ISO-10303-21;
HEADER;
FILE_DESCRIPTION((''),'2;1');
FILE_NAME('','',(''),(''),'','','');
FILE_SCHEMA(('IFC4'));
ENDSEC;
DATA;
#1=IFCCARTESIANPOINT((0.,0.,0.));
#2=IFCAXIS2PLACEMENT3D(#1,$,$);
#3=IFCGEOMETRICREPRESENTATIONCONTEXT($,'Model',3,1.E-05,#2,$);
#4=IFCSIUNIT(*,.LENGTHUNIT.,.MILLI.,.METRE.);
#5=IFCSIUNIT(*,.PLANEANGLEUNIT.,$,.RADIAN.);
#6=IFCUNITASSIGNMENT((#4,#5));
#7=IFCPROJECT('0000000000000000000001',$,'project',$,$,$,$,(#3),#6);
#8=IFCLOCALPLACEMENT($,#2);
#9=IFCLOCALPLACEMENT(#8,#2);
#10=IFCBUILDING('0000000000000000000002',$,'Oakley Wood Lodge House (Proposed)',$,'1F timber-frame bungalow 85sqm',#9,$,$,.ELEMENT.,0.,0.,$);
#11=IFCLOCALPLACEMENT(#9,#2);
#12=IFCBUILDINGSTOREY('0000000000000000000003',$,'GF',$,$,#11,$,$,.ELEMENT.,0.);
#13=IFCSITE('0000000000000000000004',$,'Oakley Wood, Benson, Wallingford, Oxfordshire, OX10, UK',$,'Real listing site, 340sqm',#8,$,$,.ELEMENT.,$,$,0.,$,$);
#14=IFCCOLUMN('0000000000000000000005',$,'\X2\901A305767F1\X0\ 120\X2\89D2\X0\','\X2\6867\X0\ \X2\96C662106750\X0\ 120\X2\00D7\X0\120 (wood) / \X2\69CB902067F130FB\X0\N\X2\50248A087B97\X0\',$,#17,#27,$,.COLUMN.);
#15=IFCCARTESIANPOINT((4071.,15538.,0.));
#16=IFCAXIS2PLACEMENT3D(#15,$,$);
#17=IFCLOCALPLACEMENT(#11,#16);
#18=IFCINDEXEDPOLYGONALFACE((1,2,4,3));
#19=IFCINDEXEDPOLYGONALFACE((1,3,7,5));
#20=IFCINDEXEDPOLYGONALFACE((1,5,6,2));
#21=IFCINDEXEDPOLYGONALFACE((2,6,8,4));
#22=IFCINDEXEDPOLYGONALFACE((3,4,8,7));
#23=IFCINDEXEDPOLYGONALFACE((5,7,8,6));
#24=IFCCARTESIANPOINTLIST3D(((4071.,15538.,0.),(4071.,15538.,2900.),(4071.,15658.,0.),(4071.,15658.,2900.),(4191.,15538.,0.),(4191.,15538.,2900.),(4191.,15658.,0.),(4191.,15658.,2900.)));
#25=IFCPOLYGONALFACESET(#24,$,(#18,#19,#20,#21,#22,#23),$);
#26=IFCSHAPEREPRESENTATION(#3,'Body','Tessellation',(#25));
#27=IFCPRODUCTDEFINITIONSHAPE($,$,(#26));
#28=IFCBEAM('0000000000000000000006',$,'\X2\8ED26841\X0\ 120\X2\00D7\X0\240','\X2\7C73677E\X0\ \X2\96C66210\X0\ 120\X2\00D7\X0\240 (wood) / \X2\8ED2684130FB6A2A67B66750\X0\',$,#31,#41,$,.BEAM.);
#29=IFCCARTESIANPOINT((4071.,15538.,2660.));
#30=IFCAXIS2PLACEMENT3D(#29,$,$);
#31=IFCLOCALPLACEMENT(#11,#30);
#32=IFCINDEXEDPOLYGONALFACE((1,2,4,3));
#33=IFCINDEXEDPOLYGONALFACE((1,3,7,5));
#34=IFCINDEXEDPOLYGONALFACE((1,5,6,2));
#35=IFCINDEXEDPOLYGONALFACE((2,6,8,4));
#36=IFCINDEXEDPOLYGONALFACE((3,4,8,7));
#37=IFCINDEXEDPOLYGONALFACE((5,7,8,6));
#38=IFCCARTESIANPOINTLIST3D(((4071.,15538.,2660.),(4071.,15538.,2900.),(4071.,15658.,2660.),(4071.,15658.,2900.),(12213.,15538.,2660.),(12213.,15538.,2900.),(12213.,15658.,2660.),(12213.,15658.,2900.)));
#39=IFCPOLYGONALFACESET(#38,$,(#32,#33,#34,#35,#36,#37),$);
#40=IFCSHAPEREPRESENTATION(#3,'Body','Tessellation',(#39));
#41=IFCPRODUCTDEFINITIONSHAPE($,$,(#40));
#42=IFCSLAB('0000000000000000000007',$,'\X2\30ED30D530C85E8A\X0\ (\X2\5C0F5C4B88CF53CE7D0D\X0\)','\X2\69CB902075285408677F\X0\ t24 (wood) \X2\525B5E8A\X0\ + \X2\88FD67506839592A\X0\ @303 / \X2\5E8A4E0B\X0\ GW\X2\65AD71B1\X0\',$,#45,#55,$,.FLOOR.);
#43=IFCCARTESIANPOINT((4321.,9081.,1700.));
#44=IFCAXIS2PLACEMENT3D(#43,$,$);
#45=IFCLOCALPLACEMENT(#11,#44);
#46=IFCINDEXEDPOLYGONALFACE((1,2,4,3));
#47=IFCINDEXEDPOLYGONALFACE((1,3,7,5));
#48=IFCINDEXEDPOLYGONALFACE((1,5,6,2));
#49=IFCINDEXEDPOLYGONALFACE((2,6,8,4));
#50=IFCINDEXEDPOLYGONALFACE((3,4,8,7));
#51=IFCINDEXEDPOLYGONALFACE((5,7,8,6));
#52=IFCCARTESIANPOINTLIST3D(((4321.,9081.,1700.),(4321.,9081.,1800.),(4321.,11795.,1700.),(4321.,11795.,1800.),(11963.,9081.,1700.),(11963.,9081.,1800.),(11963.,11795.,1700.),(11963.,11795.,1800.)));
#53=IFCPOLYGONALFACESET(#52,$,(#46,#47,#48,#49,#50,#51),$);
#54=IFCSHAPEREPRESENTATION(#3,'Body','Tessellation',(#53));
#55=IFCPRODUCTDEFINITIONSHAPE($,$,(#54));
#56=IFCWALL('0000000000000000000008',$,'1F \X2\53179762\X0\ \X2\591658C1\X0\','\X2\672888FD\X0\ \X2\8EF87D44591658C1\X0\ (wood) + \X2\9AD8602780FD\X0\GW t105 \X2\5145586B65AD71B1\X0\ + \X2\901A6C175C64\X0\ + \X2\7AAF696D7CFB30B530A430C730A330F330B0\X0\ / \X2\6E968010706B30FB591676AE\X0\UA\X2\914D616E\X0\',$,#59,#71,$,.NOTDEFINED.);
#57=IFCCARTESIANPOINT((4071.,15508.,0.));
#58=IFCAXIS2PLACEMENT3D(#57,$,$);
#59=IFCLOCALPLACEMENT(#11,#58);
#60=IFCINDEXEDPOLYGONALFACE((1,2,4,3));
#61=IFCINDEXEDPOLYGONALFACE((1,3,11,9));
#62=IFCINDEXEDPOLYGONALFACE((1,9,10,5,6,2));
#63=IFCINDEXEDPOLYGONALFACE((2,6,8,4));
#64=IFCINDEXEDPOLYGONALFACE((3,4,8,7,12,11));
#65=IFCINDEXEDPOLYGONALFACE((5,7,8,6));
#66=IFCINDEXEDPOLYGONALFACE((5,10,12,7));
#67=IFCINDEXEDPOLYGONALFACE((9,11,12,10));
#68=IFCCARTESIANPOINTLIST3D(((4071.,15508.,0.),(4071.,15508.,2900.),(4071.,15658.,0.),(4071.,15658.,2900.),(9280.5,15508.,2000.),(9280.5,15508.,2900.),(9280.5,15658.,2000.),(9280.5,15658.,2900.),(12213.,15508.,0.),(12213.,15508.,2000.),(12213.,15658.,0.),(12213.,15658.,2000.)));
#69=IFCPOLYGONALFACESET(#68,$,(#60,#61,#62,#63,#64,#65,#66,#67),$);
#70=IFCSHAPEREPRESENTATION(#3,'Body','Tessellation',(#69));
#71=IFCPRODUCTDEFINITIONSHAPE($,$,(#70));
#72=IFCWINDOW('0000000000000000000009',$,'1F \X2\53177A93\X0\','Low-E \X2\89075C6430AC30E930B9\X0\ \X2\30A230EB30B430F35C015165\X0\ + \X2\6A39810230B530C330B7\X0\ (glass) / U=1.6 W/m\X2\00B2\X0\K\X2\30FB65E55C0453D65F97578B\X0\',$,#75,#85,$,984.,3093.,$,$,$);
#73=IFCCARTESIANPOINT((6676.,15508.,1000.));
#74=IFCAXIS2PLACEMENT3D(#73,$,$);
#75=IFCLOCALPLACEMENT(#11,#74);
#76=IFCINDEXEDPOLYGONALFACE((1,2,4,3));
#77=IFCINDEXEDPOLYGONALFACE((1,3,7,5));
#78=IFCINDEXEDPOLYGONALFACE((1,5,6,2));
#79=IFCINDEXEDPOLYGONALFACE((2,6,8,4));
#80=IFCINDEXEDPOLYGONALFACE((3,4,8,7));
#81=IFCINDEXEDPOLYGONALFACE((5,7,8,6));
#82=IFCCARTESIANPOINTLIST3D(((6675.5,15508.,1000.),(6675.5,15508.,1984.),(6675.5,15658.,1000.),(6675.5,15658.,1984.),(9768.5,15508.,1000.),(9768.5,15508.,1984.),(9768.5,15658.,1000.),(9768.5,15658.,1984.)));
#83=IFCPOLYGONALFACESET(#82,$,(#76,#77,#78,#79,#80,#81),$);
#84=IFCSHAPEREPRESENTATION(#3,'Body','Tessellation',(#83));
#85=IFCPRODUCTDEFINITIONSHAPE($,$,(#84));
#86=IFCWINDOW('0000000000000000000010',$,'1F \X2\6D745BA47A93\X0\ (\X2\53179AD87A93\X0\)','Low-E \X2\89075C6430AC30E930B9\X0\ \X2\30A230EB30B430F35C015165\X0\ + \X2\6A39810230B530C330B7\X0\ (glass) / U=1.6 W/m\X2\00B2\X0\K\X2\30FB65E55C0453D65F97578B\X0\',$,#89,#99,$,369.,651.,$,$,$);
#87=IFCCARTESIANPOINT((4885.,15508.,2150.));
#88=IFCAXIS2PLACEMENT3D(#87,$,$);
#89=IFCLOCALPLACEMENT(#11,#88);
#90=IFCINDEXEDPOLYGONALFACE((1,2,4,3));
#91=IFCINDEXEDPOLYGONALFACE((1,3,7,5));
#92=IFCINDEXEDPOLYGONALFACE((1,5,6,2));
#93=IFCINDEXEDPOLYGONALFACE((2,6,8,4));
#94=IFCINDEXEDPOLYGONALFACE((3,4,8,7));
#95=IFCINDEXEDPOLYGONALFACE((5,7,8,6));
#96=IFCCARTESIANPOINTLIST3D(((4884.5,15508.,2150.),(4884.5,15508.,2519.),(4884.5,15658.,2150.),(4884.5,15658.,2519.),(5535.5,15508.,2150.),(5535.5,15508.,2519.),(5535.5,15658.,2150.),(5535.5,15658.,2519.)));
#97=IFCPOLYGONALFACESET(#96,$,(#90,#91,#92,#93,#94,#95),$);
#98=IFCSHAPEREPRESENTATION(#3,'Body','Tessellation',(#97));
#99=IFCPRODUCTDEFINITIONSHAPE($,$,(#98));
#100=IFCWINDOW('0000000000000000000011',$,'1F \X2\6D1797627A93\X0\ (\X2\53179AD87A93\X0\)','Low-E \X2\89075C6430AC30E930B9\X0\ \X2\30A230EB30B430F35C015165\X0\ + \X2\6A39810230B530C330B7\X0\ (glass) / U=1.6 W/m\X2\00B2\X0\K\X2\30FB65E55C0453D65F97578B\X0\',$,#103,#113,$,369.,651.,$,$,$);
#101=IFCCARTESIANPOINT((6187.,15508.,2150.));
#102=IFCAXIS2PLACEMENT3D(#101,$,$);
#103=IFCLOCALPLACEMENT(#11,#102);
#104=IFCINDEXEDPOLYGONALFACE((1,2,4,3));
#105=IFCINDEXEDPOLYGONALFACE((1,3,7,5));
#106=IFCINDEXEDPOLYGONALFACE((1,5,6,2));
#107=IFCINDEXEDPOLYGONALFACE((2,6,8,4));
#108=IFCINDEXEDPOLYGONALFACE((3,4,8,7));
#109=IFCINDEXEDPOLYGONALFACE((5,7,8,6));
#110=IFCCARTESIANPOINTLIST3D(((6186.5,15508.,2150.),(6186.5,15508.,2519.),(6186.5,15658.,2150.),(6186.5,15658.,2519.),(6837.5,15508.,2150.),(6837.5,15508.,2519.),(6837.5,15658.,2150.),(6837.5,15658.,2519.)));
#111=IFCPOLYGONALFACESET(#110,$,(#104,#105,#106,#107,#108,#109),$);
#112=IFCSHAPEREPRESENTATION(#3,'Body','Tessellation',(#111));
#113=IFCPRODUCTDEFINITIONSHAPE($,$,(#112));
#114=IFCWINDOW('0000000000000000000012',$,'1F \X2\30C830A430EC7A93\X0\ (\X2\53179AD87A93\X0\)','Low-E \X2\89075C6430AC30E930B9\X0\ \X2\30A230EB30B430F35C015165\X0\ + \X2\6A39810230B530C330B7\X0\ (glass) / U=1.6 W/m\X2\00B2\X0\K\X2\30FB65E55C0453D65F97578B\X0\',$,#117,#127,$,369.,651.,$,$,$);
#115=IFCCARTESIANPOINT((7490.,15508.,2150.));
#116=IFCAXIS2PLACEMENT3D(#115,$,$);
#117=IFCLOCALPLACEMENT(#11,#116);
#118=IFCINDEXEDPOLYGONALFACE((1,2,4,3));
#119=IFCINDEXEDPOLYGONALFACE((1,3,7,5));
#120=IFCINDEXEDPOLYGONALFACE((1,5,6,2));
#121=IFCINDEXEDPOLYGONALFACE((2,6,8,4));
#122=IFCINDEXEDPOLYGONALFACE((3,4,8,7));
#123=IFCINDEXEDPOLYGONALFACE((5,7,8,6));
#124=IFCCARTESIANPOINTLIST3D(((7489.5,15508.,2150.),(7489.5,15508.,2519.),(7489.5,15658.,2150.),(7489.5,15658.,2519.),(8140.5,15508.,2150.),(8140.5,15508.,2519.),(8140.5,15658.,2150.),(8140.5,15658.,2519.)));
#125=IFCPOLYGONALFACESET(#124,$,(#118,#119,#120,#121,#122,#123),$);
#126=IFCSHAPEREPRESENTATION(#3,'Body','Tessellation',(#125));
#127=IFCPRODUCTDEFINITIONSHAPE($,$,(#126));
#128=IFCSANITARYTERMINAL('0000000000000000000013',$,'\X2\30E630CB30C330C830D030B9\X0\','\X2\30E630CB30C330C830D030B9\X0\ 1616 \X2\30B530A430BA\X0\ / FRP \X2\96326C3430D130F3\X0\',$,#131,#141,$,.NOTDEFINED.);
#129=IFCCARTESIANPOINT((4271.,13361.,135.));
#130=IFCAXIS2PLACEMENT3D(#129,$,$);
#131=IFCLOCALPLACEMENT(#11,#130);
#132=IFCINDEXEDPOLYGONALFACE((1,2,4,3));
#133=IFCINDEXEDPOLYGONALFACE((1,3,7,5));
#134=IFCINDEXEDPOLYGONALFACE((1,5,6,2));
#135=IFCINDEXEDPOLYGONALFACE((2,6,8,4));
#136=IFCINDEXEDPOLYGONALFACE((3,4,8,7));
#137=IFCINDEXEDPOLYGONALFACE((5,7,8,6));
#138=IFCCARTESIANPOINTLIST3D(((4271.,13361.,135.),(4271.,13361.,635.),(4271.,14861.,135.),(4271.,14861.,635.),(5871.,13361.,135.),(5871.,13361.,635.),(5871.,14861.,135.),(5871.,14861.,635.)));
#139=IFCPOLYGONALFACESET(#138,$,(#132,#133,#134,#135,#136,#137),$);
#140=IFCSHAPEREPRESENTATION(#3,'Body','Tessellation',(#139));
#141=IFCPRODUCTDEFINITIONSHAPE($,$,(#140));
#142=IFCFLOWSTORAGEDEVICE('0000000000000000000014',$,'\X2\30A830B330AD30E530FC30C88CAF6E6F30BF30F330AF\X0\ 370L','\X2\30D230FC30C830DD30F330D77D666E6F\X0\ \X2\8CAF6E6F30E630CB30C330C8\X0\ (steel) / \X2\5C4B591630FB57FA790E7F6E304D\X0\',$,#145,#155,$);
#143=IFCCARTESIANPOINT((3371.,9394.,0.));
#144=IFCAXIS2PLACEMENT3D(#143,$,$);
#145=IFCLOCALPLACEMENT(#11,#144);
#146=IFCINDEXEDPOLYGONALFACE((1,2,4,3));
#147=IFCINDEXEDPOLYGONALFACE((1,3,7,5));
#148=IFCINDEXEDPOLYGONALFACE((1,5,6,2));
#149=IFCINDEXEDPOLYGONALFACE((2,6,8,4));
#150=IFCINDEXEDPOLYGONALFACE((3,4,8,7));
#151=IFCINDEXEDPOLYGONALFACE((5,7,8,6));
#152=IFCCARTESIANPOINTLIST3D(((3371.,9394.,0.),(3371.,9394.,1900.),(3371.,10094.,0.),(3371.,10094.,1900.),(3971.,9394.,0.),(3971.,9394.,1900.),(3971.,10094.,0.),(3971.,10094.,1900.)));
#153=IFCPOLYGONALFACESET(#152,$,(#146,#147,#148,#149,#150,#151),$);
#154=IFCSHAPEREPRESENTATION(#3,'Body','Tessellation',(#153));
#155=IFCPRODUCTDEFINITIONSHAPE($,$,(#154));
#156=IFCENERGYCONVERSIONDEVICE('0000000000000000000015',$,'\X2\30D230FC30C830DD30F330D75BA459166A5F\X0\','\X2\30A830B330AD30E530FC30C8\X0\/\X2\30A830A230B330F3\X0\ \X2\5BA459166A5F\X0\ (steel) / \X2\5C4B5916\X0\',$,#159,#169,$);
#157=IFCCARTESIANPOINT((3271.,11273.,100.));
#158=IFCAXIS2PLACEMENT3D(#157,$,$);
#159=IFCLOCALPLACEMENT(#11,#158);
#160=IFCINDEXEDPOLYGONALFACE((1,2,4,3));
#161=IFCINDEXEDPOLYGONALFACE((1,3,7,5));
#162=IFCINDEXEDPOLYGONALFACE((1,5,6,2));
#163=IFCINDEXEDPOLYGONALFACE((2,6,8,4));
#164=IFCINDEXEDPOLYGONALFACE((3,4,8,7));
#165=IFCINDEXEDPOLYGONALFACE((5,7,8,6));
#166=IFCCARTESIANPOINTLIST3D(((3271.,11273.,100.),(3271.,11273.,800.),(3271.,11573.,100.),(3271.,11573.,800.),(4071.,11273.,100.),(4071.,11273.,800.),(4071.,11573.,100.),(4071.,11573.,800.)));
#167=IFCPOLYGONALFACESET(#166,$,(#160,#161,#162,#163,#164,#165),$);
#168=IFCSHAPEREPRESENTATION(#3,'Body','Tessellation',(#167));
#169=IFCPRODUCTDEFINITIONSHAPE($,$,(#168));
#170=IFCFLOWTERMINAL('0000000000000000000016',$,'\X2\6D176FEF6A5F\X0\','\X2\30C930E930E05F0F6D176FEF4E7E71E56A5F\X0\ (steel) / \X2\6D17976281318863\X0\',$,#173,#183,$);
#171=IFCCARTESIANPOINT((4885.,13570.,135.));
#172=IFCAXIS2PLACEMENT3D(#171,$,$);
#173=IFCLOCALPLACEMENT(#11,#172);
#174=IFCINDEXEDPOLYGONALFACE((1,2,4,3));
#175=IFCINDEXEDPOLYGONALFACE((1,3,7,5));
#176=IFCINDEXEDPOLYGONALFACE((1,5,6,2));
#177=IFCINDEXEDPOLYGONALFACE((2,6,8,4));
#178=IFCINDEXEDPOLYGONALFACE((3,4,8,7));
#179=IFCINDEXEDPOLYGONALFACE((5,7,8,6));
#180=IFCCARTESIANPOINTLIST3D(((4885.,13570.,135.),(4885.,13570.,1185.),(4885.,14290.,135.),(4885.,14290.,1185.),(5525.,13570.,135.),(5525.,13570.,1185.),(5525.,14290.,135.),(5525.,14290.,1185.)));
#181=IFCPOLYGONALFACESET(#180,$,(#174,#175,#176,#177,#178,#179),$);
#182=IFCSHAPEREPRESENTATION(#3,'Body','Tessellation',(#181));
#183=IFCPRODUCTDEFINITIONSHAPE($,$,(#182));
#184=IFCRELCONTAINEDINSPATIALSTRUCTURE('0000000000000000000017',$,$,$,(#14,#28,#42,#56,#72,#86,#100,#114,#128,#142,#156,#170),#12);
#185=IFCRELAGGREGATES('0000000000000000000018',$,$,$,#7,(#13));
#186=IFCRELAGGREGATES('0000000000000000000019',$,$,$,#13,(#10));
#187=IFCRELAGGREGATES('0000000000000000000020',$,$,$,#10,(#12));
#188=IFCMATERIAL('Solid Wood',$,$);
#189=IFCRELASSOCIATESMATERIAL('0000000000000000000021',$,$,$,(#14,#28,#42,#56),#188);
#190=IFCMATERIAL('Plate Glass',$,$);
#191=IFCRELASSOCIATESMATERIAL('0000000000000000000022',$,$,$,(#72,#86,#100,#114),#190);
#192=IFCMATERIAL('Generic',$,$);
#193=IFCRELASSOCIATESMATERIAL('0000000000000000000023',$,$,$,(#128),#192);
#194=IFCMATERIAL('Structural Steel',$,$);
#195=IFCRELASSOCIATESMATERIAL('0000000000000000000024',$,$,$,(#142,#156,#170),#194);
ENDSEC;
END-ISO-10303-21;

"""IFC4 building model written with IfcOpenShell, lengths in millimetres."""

from ifc_helpers import new_model, si_unit, frame, frame_2d, origin, place, context, project, spatial, rectangle, extrude, material, element, fill, save


model = new_model("IFC4")

# Units and contexts
model_context = context("Model", 3, precision=1e-05, world=origin())
ifc_project = project(units=[si_unit("LENGTHUNIT", "METRE", prefix="MILLI"), si_unit("PLANEANGLEUNIT", "RADIAN")], contexts=[model_context])

# Site, building, storey
site_placement = place(None, origin())
site = spatial("IfcSite", under=ifc_project, at=site_placement, Name="Oakley Wood, Benson, Wallingford, Oxfordshire, OX10, UK", ObjectType="Real listing site, 340sqm", CompositionType="ELEMENT", RefElevation=0.0)
building_placement = place(site_placement, origin())
building = spatial("IfcBuilding", under=site, at=building_placement, Name="Oakley Wood Lodge House (Proposed)", ObjectType="1F timber-frame bungalow 85sqm", CompositionType="ELEMENT", ElevationOfRefHeight=0.0, ElevationOfTerrain=0.0)
storey_placement = place(building_placement, origin())
storey = spatial("IfcBuildingStorey", under=building, at=storey_placement, Name="GF", CompositionType="ELEMENT", Elevation=0.0)

# Column
ifc_material_1 = material(Name="Solid Wood")
column_1_placement = place(storey_placement, frame((4071.0, 15538.0, 0.0)))
element("IfcColumn", 1, at=column_1_placement, inside=storey, material=ifc_material_1, Name="通し柱 120角", Description="桧 集成材 120×120 (wood) / 構造柱・N値計算", PredefinedType="COLUMN", context=model_context, shape_type="SweptSolid", body=[
    extrude(rectangle(XDim=120.0, YDim=120.0, at=frame_2d((60.0, 60.0))), frame((4071.0, 15538.0, 0.0)), (0.0, 0.0, 1.0), 2900.0),
])

# Beam
beam_1_placement = place(storey_placement, frame((4071.0, 15538.0, 2660.0)))
element("IfcBeam", 2, at=beam_1_placement, inside=storey, material=ifc_material_1, Name="軒桁 120×240", Description="米松 集成 120×240 (wood) / 軒桁・横架材", PredefinedType="BEAM", context=model_context, shape_type="SweptSolid", body=[
    extrude(rectangle(XDim=8142.0, YDim=120.0, at=frame_2d((4071.0, 60.0))), frame((4071.0, 15538.0, 2660.0)), (0.0, 0.0, 1.0), 240.0),
])

# Slab
slab_placement = place(storey_placement, frame((4321.0, 9081.0, 1700.0)))
element("IfcSlab", 3, at=slab_placement, inside=storey, material=ifc_material_1, Name="ロフト床 (小屋裏収納)", Description="構造用合板 t24 (wood) 剛床 + 製材根太 @303 / 床下 GW断熱", PredefinedType="FLOOR", context=model_context, shape_type="SweptSolid", body=[
    extrude(rectangle(XDim=7642.0, YDim=2714.0, at=frame_2d((3821.0, 1357.0))), frame((4321.0, 9081.0, 1700.0)), (0.0, 0.0, 1.0), 100.0),
])

# Wall, openings, windows
wall_1_placement = place(storey_placement, frame((4071.0, 15508.0, 0.0)))
wall_1 = element("IfcWall", 4, at=wall_1_placement, inside=storey, material=ifc_material_1, Name="1F 北面 外壁", Description="木製 軸組外壁 (wood) + 高性能GW t105 充填断熱 + 通気層 + 窯業系サイディング / 準耐火・外皮UA配慮", PredefinedType="NOTDEFINED", context=model_context, shape_type="SweptSolid", body=[
    extrude(rectangle(XDim=8142.0, YDim=150.0, at=frame_2d((4071.0, 75.0))), frame((4071.0, 15508.0, 0.0)), (0.0, 0.0, 1.0), 2900.0),
])
opening_1_placement = place(storey_placement, frame((6676.0, 15508.0, 1000.0)))
opening_1 = element("IfcOpeningElement", 5, at=opening_1_placement, cuts=wall_1, PredefinedType="NOTDEFINED", context=model_context, shape_type="SweptSolid", body=[
    extrude(rectangle(XDim=3093.0, YDim=150.0, at=frame_2d((1546.0, 75.0))), frame((6676.0, 15508.0, 1000.0)), (0.0, 0.0, 1.0), 984.0),
])
opening_2_placement = place(storey_placement, frame((4885.0, 15508.0, 2150.0)))
opening_2 = element("IfcOpeningElement", 6, at=opening_2_placement, cuts=wall_1, PredefinedType="NOTDEFINED", context=model_context, shape_type="SweptSolid", body=[
    extrude(rectangle(XDim=651.0, YDim=150.0, at=frame_2d((325.0, 75.0))), frame((4885.0, 15508.0, 2150.0)), (0.0, 0.0, 1.0), 369.0),
])
opening_3_placement = place(storey_placement, frame((6187.0, 15508.0, 2150.0)))
opening_3 = element("IfcOpeningElement", 7, at=opening_3_placement, cuts=wall_1, PredefinedType="NOTDEFINED", context=model_context, shape_type="SweptSolid", body=[
    extrude(rectangle(XDim=651.0, YDim=150.0, at=frame_2d((325.0, 75.0))), frame((6187.0, 15508.0, 2150.0)), (0.0, 0.0, 1.0), 369.0),
])
opening_4_placement = place(storey_placement, frame((7490.0, 15508.0, 2150.0)))
opening_4 = element("IfcOpeningElement", 8, at=opening_4_placement, cuts=wall_1, PredefinedType="NOTDEFINED", context=model_context, shape_type="SweptSolid", body=[
    extrude(rectangle(XDim=651.0, YDim=150.0, at=frame_2d((325.0, 75.0))), frame((7490.0, 15508.0, 2150.0)), (0.0, 0.0, 1.0), 369.0),
])
ifc_material_2 = material(Name="Plate Glass")
window_1_placement = place(storey_placement, frame((6676.0, 15508.0, 1000.0)))
window_1 = element("IfcWindow", 9, at=window_1_placement, inside=storey, material=ifc_material_2, Name="1F 北窓", Description="Low-E 複層ガラス アルゴン封入 + 樹脂サッシ (glass) / U=1.6 W/m²K・日射取得型", OverallHeight=984.0, OverallWidth=3093.0, context=model_context, shape_type="SweptSolid", body=[
    extrude(rectangle(XDim=3093.0, YDim=150.0, at=frame_2d((1546.0, 75.0))), frame((6676.0, 15508.0, 1000.0)), (0.0, 0.0, 1.0), 984.0),
])
fill(opening_1, window_1)
window_2_placement = place(storey_placement, frame((4885.0, 15508.0, 2150.0)))
window_2 = element("IfcWindow", 10, at=window_2_placement, inside=storey, material=ifc_material_2, Name="1F 浴室窓 (北高窓)", Description="Low-E 複層ガラス アルゴン封入 + 樹脂サッシ (glass) / U=1.6 W/m²K・日射取得型", OverallHeight=369.0, OverallWidth=651.0, context=model_context, shape_type="SweptSolid", body=[
    extrude(rectangle(XDim=651.0, YDim=150.0, at=frame_2d((325.0, 75.0))), frame((4885.0, 15508.0, 2150.0)), (0.0, 0.0, 1.0), 369.0),
])
fill(opening_2, window_2)
window_3_placement = place(storey_placement, frame((6187.0, 15508.0, 2150.0)))
window_3 = element("IfcWindow", 11, at=window_3_placement, inside=storey, material=ifc_material_2, Name="1F 洗面窓 (北高窓)", Description="Low-E 複層ガラス アルゴン封入 + 樹脂サッシ (glass) / U=1.6 W/m²K・日射取得型", OverallHeight=369.0, OverallWidth=651.0, context=model_context, shape_type="SweptSolid", body=[
    extrude(rectangle(XDim=651.0, YDim=150.0, at=frame_2d((325.0, 75.0))), frame((6187.0, 15508.0, 2150.0)), (0.0, 0.0, 1.0), 369.0),
])
fill(opening_3, window_3)
window_4_placement = place(storey_placement, frame((7490.0, 15508.0, 2150.0)))
window_4 = element("IfcWindow", 12, at=window_4_placement, inside=storey, material=ifc_material_2, Name="1F トイレ窓 (北高窓)", Description="Low-E 複層ガラス アルゴン封入 + 樹脂サッシ (glass) / U=1.6 W/m²K・日射取得型", OverallHeight=369.0, OverallWidth=651.0, context=model_context, shape_type="SweptSolid", body=[
    extrude(rectangle(XDim=651.0, YDim=150.0, at=frame_2d((325.0, 75.0))), frame((7490.0, 15508.0, 2150.0)), (0.0, 0.0, 1.0), 369.0),
])
fill(opening_4, window_4)

# Sanitary terminal
ifc_material_3 = material(Name="Generic")
sanitary_terminal_placement = place(storey_placement, frame((4271.0, 13361.0, 135.0)))
element("IfcSanitaryTerminal", 13, at=sanitary_terminal_placement, inside=storey, material=ifc_material_3, Name="ユニットバス", Description="ユニットバス 1616 サイズ / FRP 防水パン", PredefinedType="NOTDEFINED", context=model_context, shape_type="SweptSolid", body=[
    extrude(rectangle(XDim=1600.0, YDim=1500.0, at=frame_2d((800.0, 750.0))), frame((4271.0, 13361.0, 135.0)), (0.0, 0.0, 1.0), 500.0),
])

# Flow storage device
ifc_material_4 = material(Name="Structural Steel")
flow_storage_device_placement = place(storey_placement, frame((3371.0, 9394.0, 0.0)))
element("IfcFlowStorageDevice", 14, at=flow_storage_device_placement, inside=storey, material=ifc_material_4, Name="エコキュート貯湯タンク 370L", Description="ヒートポンプ給湯 貯湯ユニット (steel) / 屋外・基礎置き", context=model_context, shape_type="SweptSolid", body=[
    extrude(rectangle(XDim=600.0, YDim=700.0, at=frame_2d((300.0, 350.0))), frame((3371.0, 9394.0, 0.0)), (0.0, 0.0, 1.0), 1900.0),
])

# Energy conversion device
energy_conversion_device_placement = place(storey_placement, frame((3271.0, 11273.0, 100.0)))
element("IfcEnergyConversionDevice", 15, at=energy_conversion_device_placement, inside=storey, material=ifc_material_4, Name="ヒートポンプ室外機", Description="エコキュート/エアコン 室外機 (steel) / 屋外", context=model_context, shape_type="SweptSolid", body=[
    extrude(rectangle(XDim=800.0, YDim=300.0, at=frame_2d((400.0, 150.0))), frame((3271.0, 11273.0, 100.0)), (0.0, 0.0, 1.0), 700.0),
])

# Flow terminal
flow_terminal_placement = place(storey_placement, frame((4885.0, 13570.0, 135.0)))
element("IfcFlowTerminal", 16, at=flow_terminal_placement, inside=storey, material=ifc_material_4, Name="洗濯機", Description="ドラム式洗濯乾燥機 (steel) / 洗面脱衣", context=model_context, shape_type="SweptSolid", body=[
    extrude(rectangle(XDim=640.0, YDim=720.0, at=frame_2d((320.0, 360.0))), frame((4885.0, 13570.0, 135.0)), (0.0, 0.0, 1.0), 1050.0),
])

save(model, "model.ifc")
